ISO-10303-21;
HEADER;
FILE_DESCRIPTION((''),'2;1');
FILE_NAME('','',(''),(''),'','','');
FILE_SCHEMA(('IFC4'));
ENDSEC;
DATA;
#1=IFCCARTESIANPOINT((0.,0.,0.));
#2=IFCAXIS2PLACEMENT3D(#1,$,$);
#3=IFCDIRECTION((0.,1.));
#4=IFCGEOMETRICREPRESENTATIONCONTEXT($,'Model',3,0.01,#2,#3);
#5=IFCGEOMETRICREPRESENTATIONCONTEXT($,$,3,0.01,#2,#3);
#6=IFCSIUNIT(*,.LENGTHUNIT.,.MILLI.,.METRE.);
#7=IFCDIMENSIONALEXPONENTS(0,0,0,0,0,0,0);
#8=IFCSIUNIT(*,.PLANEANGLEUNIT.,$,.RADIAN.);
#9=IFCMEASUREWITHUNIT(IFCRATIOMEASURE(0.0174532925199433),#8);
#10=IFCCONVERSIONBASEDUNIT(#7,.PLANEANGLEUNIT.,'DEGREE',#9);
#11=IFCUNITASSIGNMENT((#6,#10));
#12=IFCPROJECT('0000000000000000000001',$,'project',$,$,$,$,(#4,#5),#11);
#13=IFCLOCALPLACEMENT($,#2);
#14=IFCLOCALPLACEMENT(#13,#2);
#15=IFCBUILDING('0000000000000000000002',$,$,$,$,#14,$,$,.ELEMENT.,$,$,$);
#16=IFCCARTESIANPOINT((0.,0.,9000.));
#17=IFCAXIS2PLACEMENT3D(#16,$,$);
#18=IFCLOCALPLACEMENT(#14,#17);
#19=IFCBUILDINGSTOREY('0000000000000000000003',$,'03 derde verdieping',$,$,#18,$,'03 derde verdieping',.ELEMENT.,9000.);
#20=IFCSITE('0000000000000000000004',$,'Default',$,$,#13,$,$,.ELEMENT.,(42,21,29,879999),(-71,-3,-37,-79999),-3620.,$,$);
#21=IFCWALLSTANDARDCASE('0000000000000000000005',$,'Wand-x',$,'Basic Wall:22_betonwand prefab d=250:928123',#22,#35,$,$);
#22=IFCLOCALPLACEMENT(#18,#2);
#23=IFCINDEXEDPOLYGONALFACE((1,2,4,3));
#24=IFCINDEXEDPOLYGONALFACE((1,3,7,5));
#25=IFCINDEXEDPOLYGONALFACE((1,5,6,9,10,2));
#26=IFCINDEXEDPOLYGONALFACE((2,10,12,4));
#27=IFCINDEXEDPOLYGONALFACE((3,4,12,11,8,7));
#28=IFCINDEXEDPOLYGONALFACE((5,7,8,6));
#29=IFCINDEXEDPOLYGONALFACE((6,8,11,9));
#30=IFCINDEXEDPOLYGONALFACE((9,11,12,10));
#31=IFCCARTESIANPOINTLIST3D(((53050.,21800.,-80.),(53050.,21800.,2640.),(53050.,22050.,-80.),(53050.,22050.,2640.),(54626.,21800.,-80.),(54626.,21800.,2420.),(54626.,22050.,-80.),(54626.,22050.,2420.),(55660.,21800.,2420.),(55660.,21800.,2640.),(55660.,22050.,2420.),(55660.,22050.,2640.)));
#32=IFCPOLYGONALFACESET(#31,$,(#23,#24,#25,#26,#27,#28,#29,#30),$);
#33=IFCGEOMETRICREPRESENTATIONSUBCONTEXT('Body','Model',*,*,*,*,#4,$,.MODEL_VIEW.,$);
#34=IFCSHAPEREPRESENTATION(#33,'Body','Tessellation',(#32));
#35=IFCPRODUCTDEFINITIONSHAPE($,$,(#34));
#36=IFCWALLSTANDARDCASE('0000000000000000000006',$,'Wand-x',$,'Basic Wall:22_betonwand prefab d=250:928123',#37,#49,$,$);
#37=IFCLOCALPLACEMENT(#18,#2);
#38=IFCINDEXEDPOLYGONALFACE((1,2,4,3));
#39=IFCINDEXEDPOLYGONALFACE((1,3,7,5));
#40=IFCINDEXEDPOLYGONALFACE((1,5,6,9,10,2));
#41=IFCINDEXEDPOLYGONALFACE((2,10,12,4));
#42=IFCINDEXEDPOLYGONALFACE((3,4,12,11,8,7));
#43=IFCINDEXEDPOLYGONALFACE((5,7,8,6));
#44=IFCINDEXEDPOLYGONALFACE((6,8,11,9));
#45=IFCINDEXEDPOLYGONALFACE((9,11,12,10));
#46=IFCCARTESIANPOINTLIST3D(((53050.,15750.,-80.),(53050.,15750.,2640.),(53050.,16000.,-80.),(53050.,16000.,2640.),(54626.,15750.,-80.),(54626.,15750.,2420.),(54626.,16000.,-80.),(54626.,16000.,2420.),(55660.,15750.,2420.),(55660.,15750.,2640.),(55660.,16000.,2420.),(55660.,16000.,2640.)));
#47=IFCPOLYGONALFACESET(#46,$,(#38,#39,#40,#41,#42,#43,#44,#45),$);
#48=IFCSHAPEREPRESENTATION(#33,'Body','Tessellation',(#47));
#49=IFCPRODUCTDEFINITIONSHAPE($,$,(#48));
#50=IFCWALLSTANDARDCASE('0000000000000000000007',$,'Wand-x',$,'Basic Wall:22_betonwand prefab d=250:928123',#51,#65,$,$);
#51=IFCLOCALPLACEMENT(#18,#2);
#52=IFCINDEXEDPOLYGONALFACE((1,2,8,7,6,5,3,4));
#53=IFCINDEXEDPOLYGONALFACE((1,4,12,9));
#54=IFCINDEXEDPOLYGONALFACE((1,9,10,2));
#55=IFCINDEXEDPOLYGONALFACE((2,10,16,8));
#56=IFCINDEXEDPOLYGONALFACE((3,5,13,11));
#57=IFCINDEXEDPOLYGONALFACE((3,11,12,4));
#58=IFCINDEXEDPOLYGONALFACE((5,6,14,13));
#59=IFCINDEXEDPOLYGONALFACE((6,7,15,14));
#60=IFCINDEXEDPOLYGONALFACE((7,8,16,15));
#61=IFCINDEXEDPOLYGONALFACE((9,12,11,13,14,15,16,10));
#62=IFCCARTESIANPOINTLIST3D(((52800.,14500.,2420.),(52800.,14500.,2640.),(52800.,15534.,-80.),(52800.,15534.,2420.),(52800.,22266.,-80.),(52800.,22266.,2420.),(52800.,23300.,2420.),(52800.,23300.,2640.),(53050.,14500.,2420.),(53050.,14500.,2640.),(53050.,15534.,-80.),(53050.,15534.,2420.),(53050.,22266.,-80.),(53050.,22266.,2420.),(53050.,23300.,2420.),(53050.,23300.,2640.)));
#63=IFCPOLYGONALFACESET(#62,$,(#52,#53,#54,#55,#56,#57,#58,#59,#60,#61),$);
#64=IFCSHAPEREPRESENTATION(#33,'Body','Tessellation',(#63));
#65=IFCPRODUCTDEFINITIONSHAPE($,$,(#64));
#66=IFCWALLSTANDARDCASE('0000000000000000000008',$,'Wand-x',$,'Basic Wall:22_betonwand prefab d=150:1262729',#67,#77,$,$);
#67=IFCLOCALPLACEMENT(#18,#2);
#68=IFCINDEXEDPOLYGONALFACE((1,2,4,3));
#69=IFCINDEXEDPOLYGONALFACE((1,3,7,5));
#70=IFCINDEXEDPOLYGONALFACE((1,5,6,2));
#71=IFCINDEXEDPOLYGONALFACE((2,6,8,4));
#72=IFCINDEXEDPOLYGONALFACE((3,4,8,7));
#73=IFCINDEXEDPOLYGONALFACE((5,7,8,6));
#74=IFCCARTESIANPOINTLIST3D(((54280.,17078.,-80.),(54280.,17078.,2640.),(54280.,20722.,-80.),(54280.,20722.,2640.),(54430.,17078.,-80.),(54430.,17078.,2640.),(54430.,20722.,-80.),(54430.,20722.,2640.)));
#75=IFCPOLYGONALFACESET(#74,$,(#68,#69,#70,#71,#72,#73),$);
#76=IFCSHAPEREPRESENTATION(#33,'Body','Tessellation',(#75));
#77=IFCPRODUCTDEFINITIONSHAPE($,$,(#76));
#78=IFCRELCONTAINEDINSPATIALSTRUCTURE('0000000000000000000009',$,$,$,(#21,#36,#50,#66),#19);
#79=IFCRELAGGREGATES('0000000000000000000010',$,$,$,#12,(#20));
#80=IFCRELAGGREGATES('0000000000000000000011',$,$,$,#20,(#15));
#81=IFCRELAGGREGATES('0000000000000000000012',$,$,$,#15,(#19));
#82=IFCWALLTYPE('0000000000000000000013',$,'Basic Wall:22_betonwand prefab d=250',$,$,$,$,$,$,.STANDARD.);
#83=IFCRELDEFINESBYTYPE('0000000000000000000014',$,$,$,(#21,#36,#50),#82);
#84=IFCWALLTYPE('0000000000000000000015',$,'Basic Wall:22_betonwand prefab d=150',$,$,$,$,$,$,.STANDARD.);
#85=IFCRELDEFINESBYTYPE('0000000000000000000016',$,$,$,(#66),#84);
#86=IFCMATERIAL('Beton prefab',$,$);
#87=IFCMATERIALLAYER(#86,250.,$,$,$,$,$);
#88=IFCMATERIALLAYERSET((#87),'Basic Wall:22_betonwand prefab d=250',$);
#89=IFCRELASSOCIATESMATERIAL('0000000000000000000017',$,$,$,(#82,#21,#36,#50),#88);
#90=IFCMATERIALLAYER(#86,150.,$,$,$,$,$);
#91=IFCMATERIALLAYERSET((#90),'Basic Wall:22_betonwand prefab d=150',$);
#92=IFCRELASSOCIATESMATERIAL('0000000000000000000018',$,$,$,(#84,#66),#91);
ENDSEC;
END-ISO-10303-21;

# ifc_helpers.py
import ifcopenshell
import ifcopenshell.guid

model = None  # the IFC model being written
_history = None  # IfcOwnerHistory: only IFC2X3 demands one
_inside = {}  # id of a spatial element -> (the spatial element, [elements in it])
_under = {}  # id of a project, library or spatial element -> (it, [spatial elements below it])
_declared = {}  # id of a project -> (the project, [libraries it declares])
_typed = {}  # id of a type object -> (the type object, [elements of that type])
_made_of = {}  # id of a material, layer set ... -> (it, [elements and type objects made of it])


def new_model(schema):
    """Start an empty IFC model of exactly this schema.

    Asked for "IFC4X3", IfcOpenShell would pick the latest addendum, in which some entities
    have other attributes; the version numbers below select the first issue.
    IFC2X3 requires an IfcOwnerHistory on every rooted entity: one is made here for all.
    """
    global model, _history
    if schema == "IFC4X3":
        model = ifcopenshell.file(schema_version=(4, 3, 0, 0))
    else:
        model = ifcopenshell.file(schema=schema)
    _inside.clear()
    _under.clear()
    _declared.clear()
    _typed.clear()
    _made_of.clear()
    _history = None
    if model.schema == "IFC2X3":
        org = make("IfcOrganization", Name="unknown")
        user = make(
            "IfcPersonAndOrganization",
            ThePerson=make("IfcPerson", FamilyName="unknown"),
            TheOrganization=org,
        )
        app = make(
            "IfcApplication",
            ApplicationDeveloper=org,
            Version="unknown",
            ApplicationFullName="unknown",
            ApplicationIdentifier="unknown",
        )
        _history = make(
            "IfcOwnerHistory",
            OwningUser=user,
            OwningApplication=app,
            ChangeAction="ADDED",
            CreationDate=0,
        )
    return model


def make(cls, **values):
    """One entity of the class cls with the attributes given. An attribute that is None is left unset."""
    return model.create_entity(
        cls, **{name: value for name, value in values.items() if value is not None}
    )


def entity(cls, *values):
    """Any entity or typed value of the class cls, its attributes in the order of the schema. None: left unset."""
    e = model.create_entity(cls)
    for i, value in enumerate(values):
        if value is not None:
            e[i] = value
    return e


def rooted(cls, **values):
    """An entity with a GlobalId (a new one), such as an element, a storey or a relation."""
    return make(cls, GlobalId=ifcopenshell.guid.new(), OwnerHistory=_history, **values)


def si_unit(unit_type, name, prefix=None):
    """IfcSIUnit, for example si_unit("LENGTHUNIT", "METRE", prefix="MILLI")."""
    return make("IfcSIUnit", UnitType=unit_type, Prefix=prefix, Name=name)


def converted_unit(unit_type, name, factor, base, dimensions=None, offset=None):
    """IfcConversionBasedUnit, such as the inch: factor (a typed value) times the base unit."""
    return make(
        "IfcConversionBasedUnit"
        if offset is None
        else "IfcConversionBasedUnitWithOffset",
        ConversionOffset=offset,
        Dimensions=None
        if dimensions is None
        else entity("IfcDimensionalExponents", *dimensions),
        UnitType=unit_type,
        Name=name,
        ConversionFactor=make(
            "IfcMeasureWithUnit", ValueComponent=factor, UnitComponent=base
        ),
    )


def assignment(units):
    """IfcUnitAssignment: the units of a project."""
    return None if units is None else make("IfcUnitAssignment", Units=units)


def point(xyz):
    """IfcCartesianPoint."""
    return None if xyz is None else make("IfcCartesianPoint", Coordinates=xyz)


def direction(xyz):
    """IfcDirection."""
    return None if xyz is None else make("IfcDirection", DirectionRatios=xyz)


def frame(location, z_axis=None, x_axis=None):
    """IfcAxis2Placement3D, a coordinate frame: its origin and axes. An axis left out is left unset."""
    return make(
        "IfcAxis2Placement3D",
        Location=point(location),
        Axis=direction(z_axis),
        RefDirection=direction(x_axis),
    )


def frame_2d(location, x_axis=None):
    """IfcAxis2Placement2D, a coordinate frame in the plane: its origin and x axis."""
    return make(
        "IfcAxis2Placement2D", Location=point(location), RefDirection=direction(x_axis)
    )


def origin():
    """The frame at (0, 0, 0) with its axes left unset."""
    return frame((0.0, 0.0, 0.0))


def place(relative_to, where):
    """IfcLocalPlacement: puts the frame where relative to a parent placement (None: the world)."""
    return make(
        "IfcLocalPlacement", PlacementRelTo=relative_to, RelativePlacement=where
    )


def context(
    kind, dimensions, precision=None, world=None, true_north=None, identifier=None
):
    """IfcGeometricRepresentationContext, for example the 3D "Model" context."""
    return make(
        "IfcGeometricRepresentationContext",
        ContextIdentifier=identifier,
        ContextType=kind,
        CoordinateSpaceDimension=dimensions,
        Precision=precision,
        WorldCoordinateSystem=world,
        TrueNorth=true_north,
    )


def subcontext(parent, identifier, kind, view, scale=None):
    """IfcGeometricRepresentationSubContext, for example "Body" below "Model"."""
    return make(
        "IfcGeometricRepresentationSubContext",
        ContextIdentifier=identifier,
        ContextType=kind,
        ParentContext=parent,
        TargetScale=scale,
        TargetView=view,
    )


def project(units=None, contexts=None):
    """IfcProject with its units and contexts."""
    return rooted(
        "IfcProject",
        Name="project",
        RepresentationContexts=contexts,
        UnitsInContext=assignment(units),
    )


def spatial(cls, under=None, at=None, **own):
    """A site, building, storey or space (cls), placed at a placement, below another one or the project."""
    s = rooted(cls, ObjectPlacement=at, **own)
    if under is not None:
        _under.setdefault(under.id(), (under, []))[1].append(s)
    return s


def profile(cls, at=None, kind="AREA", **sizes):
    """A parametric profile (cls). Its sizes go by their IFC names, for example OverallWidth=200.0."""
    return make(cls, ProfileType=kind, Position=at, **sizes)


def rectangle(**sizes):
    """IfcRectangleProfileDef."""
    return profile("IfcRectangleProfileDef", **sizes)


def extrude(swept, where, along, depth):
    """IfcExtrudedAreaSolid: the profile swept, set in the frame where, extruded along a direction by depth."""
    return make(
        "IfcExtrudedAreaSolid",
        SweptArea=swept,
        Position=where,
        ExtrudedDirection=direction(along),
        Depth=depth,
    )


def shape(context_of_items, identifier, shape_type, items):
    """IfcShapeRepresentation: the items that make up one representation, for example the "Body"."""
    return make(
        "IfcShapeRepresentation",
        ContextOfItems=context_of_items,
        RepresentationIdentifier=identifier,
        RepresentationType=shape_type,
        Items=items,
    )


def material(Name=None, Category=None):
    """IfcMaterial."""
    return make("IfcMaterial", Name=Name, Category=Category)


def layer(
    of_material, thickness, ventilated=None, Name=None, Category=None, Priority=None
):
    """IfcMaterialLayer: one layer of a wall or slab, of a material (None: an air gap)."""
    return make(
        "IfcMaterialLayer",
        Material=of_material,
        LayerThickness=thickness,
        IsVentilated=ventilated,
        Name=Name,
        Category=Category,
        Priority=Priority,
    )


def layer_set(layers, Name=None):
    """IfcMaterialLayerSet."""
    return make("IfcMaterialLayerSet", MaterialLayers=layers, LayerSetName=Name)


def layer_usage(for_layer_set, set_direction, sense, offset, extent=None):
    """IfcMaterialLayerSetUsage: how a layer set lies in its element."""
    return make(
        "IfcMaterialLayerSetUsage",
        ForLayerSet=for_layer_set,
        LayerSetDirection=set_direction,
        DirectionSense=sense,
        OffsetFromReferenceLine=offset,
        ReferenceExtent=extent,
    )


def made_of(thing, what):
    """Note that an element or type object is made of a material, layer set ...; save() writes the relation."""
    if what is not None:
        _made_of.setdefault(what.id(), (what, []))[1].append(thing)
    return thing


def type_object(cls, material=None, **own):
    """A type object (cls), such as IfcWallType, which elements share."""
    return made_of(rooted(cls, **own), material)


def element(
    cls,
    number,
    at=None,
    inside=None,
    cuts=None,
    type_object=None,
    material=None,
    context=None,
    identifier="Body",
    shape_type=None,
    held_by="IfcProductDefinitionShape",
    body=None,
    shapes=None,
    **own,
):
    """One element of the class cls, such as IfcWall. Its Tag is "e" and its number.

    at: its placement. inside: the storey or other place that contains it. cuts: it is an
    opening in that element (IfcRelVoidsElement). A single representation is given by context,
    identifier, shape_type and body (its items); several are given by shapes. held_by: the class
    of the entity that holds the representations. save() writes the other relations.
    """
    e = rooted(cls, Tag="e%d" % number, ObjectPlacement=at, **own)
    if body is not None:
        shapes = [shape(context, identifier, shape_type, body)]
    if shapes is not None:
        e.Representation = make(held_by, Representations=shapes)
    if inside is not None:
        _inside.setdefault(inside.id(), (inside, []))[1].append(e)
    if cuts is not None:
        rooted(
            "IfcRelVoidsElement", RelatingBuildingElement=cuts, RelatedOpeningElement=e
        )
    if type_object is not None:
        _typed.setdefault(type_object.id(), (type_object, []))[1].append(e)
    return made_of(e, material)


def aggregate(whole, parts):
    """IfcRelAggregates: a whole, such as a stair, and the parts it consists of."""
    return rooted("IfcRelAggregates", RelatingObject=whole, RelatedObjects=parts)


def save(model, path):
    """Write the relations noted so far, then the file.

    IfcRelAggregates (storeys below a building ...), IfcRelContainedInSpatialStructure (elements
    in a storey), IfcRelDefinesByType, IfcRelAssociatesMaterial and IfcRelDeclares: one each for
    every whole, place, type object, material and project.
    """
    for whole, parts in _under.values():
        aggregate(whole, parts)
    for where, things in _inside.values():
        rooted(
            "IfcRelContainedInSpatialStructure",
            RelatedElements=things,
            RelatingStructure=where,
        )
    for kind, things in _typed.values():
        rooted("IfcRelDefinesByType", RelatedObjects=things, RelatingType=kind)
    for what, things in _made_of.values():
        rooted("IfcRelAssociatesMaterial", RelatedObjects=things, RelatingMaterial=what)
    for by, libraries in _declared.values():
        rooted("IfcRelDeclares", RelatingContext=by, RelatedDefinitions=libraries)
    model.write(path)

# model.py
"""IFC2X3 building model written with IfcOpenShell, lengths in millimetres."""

from ifc_helpers import new_model, entity, si_unit, converted_unit, direction, frame, frame_2d, origin, place, context, subcontext, project, spatial, rectangle, extrude, material, layer, layer_set, layer_usage, type_object, element, save


model = new_model("IFC2X3")

# Units and contexts
model_context = context("Model", 3, precision=0.01, world=origin(), true_north=direction((0.0, 1.0)))
context_of_model = context(None, 3, precision=0.01, world=origin(), true_north=direction((0.0, 1.0)))
body_context = subcontext(model_context, "Body", "Model", "MODEL_VIEW")
ifc_project = project(units=[si_unit("LENGTHUNIT", "METRE", prefix="MILLI"), converted_unit("PLANEANGLEUNIT", "DEGREE", entity("IfcRatioMeasure", 0.0174532925199433), si_unit("PLANEANGLEUNIT", "RADIAN"), dimensions=[0, 0, 0, 0, 0, 0, 0])], contexts=[model_context, context_of_model])

# Site, building, storey
site_placement = place(None, origin())
site = spatial("IfcSite", under=ifc_project, at=site_placement, Name="Default", CompositionType="ELEMENT", RefLatitude=(42, 21, 29, 879999), RefLongitude=(-71, -3, -37, -79999), RefElevation=-3620.0)
building_placement = place(site_placement, origin())
building = spatial("IfcBuilding", under=site, at=building_placement, CompositionType="ELEMENT")
storey_placement = place(building_placement, frame((0.0, 0.0, 9000.0)))
storey = spatial("IfcBuildingStorey", under=building, at=storey_placement, Name="03 derde verdieping", LongName="03 derde verdieping", CompositionType="ELEMENT", Elevation=9000.0)

# Shared definitions
ifc_material_1 = material(Name="Beton prefab")

# Walls, openings
ifc_layer_1 = layer(ifc_material_1, 250.0)
ifc_layer_set_1 = layer_set([ifc_layer_1], Name="Basic Wall:22_betonwand prefab d=250")
ifc_layer_usage_1 = layer_usage(ifc_layer_set_1, "AXIS2", "NEGATIVE", 125.0)
wall_type_1 = type_object("IfcWallType", Name="Basic Wall:22_betonwand prefab d=250", PredefinedType="STANDARD", material=ifc_layer_set_1)
wall_1_placement = place(storey_placement, frame((53050.0, 21925.0, -80.0)))
wall_1 = element("IfcWallStandardCase", 1, at=wall_1_placement, inside=storey, type_object=wall_type_1, material=ifc_layer_usage_1, Name="Wand-x", ObjectType="Basic Wall:22_betonwand prefab d=250:928123", context=body_context, shape_type="SweptSolid", body=[
    extrude(rectangle(XDim=2610.0, YDim=250.0, at=frame_2d((1305.0, 0.0), x_axis=(-1.0, 0.0))), origin(), (0.0, 0.0, 1.0), 2720.0),
])
opening_1_placement = place(wall_1_placement, frame((-53050.0, -21925.0, 80.0)))
element("IfcOpeningElement", 2, at=opening_1_placement, cuts=wall_1, ObjectType="Opening", context=body_context, shape_type="SweptSolid", body=[
    extrude(rectangle(XDim=2500.0, YDim=1034.0, at=frame_2d((0.0, 0.0), x_axis=(1.0, 0.0))), frame((55143.0, 21525.0, 1170.0), z_axis=(0.0, 1.0, 0.0), x_axis=(0.0, 0.0, -1.0)), (0.0, 0.0, 1.0), 800.0),
])
ifc_layer_usage_2 = layer_usage(ifc_layer_set_1, "AXIS2", "POSITIVE", -125.0)
wall_2_placement = place(storey_placement, frame((53050.0, 15875.0, -80.0)))
wall_2 = element("IfcWallStandardCase", 3, at=wall_2_placement, inside=storey, type_object=wall_type_1, material=ifc_layer_usage_2, Name="Wand-x", ObjectType="Basic Wall:22_betonwand prefab d=250:928123", context=body_context, shape_type="SweptSolid", body=[
    extrude(rectangle(XDim=2610.0, YDim=250.0, at=frame_2d((1305.0, 0.0), x_axis=(-1.0, 0.0))), origin(), (0.0, 0.0, 1.0), 2720.0),
])
opening_2_placement = place(wall_2_placement, frame((-53050.0, -15875.0, 80.0)))
element("IfcOpeningElement", 4, at=opening_2_placement, cuts=wall_2, ObjectType="Opening", context=body_context, shape_type="SweptSolid", body=[
    extrude(rectangle(XDim=2500.0, YDim=1034.0, at=frame_2d((0.0, 0.0), x_axis=(1.0, 0.0))), frame((55143.0, 15475.0, 1170.0), z_axis=(0.0, 1.0, 0.0), x_axis=(0.0, 0.0, -1.0)), (0.0, 0.0, 1.0), 800.0),
])

# Wall, openings
ifc_layer_usage_3 = layer_usage(ifc_layer_set_1, "AXIS2", "NEGATIVE", 125.0)
wall_3_placement = place(storey_placement, frame((52925.0, 14500.0, -80.0), z_axis=(0.0, 0.0, 1.0), x_axis=(0.0, 1.0, 0.0)))
wall_3 = element("IfcWallStandardCase", 5, at=wall_3_placement, inside=storey, type_object=wall_type_1, material=ifc_layer_usage_3, Name="Wand-x", ObjectType="Basic Wall:22_betonwand prefab d=250:928123", context=body_context, shape_type="SweptSolid", body=[
    extrude(rectangle(XDim=8800.0, YDim=250.0, at=frame_2d((4400.0, 0.0), x_axis=(-1.0, 0.0))), origin(), (0.0, 0.0, 1.0), 2720.0),
])
opening_3_placement = place(wall_3_placement, frame((-14500.0, 52925.0, 80.0), z_axis=(0.0, 0.0, 1.0), x_axis=(0.0, -1.0, 0.0)))
element("IfcOpeningElement", 6, at=opening_3_placement, cuts=wall_3, ObjectType="Opening", context=body_context, shape_type="SweptSolid", body=[
    extrude(rectangle(XDim=2500.0, YDim=1034.0, at=frame_2d((0.0, 0.0), x_axis=(1.0, 0.0))), frame((53325.0, 15017.0, 1170.0), z_axis=(-1.0, 0.0, 0.0), x_axis=(0.0, 0.0, -1.0)), (0.0, 0.0, 1.0), 800.0),
])
opening_4_placement = place(wall_3_placement, frame((-14500.0, 52925.0, 80.0), z_axis=(0.0, 0.0, 1.0), x_axis=(0.0, -1.0, 0.0)))
element("IfcOpeningElement", 7, at=opening_4_placement, cuts=wall_3, ObjectType="Opening", context=body_context, shape_type="SweptSolid", body=[
    extrude(rectangle(XDim=2500.0, YDim=1034.0, at=frame_2d((0.0, 0.0), x_axis=(0.0, 1.0))), frame((53325.0, 22783.0, 1170.0), z_axis=(-1.0, 0.0, 0.0), x_axis=(0.0, 1.0, 0.0)), (0.0, 0.0, 1.0), 800.0),
])

# Wall
ifc_layer_2 = layer(ifc_material_1, 150.0)
ifc_layer_set_2 = layer_set([ifc_layer_2], Name="Basic Wall:22_betonwand prefab d=150")
ifc_layer_usage_4 = layer_usage(ifc_layer_set_2, "AXIS2", "NEGATIVE", 75.0)
wall_type_2 = type_object("IfcWallType", Name="Basic Wall:22_betonwand prefab d=150", PredefinedType="STANDARD", material=ifc_layer_set_2)
wall_4_placement = place(storey_placement, frame((54355.0, 17078.0, -80.0), z_axis=(0.0, 0.0, 1.0), x_axis=(0.0, 1.0, 0.0)))
element("IfcWallStandardCase", 8, at=wall_4_placement, inside=storey, type_object=wall_type_2, material=ifc_layer_usage_4, Name="Wand-x", ObjectType="Basic Wall:22_betonwand prefab d=150:1262729", context=body_context, shape_type="SweptSolid", body=[
    extrude(rectangle(XDim=3644.0, YDim=150.0, at=frame_2d((1822.0, 0.0), x_axis=(-1.0, 0.0))), origin(), (0.0, 0.0, 1.0), 2720.0),
])

save(model, "model.ifc")
